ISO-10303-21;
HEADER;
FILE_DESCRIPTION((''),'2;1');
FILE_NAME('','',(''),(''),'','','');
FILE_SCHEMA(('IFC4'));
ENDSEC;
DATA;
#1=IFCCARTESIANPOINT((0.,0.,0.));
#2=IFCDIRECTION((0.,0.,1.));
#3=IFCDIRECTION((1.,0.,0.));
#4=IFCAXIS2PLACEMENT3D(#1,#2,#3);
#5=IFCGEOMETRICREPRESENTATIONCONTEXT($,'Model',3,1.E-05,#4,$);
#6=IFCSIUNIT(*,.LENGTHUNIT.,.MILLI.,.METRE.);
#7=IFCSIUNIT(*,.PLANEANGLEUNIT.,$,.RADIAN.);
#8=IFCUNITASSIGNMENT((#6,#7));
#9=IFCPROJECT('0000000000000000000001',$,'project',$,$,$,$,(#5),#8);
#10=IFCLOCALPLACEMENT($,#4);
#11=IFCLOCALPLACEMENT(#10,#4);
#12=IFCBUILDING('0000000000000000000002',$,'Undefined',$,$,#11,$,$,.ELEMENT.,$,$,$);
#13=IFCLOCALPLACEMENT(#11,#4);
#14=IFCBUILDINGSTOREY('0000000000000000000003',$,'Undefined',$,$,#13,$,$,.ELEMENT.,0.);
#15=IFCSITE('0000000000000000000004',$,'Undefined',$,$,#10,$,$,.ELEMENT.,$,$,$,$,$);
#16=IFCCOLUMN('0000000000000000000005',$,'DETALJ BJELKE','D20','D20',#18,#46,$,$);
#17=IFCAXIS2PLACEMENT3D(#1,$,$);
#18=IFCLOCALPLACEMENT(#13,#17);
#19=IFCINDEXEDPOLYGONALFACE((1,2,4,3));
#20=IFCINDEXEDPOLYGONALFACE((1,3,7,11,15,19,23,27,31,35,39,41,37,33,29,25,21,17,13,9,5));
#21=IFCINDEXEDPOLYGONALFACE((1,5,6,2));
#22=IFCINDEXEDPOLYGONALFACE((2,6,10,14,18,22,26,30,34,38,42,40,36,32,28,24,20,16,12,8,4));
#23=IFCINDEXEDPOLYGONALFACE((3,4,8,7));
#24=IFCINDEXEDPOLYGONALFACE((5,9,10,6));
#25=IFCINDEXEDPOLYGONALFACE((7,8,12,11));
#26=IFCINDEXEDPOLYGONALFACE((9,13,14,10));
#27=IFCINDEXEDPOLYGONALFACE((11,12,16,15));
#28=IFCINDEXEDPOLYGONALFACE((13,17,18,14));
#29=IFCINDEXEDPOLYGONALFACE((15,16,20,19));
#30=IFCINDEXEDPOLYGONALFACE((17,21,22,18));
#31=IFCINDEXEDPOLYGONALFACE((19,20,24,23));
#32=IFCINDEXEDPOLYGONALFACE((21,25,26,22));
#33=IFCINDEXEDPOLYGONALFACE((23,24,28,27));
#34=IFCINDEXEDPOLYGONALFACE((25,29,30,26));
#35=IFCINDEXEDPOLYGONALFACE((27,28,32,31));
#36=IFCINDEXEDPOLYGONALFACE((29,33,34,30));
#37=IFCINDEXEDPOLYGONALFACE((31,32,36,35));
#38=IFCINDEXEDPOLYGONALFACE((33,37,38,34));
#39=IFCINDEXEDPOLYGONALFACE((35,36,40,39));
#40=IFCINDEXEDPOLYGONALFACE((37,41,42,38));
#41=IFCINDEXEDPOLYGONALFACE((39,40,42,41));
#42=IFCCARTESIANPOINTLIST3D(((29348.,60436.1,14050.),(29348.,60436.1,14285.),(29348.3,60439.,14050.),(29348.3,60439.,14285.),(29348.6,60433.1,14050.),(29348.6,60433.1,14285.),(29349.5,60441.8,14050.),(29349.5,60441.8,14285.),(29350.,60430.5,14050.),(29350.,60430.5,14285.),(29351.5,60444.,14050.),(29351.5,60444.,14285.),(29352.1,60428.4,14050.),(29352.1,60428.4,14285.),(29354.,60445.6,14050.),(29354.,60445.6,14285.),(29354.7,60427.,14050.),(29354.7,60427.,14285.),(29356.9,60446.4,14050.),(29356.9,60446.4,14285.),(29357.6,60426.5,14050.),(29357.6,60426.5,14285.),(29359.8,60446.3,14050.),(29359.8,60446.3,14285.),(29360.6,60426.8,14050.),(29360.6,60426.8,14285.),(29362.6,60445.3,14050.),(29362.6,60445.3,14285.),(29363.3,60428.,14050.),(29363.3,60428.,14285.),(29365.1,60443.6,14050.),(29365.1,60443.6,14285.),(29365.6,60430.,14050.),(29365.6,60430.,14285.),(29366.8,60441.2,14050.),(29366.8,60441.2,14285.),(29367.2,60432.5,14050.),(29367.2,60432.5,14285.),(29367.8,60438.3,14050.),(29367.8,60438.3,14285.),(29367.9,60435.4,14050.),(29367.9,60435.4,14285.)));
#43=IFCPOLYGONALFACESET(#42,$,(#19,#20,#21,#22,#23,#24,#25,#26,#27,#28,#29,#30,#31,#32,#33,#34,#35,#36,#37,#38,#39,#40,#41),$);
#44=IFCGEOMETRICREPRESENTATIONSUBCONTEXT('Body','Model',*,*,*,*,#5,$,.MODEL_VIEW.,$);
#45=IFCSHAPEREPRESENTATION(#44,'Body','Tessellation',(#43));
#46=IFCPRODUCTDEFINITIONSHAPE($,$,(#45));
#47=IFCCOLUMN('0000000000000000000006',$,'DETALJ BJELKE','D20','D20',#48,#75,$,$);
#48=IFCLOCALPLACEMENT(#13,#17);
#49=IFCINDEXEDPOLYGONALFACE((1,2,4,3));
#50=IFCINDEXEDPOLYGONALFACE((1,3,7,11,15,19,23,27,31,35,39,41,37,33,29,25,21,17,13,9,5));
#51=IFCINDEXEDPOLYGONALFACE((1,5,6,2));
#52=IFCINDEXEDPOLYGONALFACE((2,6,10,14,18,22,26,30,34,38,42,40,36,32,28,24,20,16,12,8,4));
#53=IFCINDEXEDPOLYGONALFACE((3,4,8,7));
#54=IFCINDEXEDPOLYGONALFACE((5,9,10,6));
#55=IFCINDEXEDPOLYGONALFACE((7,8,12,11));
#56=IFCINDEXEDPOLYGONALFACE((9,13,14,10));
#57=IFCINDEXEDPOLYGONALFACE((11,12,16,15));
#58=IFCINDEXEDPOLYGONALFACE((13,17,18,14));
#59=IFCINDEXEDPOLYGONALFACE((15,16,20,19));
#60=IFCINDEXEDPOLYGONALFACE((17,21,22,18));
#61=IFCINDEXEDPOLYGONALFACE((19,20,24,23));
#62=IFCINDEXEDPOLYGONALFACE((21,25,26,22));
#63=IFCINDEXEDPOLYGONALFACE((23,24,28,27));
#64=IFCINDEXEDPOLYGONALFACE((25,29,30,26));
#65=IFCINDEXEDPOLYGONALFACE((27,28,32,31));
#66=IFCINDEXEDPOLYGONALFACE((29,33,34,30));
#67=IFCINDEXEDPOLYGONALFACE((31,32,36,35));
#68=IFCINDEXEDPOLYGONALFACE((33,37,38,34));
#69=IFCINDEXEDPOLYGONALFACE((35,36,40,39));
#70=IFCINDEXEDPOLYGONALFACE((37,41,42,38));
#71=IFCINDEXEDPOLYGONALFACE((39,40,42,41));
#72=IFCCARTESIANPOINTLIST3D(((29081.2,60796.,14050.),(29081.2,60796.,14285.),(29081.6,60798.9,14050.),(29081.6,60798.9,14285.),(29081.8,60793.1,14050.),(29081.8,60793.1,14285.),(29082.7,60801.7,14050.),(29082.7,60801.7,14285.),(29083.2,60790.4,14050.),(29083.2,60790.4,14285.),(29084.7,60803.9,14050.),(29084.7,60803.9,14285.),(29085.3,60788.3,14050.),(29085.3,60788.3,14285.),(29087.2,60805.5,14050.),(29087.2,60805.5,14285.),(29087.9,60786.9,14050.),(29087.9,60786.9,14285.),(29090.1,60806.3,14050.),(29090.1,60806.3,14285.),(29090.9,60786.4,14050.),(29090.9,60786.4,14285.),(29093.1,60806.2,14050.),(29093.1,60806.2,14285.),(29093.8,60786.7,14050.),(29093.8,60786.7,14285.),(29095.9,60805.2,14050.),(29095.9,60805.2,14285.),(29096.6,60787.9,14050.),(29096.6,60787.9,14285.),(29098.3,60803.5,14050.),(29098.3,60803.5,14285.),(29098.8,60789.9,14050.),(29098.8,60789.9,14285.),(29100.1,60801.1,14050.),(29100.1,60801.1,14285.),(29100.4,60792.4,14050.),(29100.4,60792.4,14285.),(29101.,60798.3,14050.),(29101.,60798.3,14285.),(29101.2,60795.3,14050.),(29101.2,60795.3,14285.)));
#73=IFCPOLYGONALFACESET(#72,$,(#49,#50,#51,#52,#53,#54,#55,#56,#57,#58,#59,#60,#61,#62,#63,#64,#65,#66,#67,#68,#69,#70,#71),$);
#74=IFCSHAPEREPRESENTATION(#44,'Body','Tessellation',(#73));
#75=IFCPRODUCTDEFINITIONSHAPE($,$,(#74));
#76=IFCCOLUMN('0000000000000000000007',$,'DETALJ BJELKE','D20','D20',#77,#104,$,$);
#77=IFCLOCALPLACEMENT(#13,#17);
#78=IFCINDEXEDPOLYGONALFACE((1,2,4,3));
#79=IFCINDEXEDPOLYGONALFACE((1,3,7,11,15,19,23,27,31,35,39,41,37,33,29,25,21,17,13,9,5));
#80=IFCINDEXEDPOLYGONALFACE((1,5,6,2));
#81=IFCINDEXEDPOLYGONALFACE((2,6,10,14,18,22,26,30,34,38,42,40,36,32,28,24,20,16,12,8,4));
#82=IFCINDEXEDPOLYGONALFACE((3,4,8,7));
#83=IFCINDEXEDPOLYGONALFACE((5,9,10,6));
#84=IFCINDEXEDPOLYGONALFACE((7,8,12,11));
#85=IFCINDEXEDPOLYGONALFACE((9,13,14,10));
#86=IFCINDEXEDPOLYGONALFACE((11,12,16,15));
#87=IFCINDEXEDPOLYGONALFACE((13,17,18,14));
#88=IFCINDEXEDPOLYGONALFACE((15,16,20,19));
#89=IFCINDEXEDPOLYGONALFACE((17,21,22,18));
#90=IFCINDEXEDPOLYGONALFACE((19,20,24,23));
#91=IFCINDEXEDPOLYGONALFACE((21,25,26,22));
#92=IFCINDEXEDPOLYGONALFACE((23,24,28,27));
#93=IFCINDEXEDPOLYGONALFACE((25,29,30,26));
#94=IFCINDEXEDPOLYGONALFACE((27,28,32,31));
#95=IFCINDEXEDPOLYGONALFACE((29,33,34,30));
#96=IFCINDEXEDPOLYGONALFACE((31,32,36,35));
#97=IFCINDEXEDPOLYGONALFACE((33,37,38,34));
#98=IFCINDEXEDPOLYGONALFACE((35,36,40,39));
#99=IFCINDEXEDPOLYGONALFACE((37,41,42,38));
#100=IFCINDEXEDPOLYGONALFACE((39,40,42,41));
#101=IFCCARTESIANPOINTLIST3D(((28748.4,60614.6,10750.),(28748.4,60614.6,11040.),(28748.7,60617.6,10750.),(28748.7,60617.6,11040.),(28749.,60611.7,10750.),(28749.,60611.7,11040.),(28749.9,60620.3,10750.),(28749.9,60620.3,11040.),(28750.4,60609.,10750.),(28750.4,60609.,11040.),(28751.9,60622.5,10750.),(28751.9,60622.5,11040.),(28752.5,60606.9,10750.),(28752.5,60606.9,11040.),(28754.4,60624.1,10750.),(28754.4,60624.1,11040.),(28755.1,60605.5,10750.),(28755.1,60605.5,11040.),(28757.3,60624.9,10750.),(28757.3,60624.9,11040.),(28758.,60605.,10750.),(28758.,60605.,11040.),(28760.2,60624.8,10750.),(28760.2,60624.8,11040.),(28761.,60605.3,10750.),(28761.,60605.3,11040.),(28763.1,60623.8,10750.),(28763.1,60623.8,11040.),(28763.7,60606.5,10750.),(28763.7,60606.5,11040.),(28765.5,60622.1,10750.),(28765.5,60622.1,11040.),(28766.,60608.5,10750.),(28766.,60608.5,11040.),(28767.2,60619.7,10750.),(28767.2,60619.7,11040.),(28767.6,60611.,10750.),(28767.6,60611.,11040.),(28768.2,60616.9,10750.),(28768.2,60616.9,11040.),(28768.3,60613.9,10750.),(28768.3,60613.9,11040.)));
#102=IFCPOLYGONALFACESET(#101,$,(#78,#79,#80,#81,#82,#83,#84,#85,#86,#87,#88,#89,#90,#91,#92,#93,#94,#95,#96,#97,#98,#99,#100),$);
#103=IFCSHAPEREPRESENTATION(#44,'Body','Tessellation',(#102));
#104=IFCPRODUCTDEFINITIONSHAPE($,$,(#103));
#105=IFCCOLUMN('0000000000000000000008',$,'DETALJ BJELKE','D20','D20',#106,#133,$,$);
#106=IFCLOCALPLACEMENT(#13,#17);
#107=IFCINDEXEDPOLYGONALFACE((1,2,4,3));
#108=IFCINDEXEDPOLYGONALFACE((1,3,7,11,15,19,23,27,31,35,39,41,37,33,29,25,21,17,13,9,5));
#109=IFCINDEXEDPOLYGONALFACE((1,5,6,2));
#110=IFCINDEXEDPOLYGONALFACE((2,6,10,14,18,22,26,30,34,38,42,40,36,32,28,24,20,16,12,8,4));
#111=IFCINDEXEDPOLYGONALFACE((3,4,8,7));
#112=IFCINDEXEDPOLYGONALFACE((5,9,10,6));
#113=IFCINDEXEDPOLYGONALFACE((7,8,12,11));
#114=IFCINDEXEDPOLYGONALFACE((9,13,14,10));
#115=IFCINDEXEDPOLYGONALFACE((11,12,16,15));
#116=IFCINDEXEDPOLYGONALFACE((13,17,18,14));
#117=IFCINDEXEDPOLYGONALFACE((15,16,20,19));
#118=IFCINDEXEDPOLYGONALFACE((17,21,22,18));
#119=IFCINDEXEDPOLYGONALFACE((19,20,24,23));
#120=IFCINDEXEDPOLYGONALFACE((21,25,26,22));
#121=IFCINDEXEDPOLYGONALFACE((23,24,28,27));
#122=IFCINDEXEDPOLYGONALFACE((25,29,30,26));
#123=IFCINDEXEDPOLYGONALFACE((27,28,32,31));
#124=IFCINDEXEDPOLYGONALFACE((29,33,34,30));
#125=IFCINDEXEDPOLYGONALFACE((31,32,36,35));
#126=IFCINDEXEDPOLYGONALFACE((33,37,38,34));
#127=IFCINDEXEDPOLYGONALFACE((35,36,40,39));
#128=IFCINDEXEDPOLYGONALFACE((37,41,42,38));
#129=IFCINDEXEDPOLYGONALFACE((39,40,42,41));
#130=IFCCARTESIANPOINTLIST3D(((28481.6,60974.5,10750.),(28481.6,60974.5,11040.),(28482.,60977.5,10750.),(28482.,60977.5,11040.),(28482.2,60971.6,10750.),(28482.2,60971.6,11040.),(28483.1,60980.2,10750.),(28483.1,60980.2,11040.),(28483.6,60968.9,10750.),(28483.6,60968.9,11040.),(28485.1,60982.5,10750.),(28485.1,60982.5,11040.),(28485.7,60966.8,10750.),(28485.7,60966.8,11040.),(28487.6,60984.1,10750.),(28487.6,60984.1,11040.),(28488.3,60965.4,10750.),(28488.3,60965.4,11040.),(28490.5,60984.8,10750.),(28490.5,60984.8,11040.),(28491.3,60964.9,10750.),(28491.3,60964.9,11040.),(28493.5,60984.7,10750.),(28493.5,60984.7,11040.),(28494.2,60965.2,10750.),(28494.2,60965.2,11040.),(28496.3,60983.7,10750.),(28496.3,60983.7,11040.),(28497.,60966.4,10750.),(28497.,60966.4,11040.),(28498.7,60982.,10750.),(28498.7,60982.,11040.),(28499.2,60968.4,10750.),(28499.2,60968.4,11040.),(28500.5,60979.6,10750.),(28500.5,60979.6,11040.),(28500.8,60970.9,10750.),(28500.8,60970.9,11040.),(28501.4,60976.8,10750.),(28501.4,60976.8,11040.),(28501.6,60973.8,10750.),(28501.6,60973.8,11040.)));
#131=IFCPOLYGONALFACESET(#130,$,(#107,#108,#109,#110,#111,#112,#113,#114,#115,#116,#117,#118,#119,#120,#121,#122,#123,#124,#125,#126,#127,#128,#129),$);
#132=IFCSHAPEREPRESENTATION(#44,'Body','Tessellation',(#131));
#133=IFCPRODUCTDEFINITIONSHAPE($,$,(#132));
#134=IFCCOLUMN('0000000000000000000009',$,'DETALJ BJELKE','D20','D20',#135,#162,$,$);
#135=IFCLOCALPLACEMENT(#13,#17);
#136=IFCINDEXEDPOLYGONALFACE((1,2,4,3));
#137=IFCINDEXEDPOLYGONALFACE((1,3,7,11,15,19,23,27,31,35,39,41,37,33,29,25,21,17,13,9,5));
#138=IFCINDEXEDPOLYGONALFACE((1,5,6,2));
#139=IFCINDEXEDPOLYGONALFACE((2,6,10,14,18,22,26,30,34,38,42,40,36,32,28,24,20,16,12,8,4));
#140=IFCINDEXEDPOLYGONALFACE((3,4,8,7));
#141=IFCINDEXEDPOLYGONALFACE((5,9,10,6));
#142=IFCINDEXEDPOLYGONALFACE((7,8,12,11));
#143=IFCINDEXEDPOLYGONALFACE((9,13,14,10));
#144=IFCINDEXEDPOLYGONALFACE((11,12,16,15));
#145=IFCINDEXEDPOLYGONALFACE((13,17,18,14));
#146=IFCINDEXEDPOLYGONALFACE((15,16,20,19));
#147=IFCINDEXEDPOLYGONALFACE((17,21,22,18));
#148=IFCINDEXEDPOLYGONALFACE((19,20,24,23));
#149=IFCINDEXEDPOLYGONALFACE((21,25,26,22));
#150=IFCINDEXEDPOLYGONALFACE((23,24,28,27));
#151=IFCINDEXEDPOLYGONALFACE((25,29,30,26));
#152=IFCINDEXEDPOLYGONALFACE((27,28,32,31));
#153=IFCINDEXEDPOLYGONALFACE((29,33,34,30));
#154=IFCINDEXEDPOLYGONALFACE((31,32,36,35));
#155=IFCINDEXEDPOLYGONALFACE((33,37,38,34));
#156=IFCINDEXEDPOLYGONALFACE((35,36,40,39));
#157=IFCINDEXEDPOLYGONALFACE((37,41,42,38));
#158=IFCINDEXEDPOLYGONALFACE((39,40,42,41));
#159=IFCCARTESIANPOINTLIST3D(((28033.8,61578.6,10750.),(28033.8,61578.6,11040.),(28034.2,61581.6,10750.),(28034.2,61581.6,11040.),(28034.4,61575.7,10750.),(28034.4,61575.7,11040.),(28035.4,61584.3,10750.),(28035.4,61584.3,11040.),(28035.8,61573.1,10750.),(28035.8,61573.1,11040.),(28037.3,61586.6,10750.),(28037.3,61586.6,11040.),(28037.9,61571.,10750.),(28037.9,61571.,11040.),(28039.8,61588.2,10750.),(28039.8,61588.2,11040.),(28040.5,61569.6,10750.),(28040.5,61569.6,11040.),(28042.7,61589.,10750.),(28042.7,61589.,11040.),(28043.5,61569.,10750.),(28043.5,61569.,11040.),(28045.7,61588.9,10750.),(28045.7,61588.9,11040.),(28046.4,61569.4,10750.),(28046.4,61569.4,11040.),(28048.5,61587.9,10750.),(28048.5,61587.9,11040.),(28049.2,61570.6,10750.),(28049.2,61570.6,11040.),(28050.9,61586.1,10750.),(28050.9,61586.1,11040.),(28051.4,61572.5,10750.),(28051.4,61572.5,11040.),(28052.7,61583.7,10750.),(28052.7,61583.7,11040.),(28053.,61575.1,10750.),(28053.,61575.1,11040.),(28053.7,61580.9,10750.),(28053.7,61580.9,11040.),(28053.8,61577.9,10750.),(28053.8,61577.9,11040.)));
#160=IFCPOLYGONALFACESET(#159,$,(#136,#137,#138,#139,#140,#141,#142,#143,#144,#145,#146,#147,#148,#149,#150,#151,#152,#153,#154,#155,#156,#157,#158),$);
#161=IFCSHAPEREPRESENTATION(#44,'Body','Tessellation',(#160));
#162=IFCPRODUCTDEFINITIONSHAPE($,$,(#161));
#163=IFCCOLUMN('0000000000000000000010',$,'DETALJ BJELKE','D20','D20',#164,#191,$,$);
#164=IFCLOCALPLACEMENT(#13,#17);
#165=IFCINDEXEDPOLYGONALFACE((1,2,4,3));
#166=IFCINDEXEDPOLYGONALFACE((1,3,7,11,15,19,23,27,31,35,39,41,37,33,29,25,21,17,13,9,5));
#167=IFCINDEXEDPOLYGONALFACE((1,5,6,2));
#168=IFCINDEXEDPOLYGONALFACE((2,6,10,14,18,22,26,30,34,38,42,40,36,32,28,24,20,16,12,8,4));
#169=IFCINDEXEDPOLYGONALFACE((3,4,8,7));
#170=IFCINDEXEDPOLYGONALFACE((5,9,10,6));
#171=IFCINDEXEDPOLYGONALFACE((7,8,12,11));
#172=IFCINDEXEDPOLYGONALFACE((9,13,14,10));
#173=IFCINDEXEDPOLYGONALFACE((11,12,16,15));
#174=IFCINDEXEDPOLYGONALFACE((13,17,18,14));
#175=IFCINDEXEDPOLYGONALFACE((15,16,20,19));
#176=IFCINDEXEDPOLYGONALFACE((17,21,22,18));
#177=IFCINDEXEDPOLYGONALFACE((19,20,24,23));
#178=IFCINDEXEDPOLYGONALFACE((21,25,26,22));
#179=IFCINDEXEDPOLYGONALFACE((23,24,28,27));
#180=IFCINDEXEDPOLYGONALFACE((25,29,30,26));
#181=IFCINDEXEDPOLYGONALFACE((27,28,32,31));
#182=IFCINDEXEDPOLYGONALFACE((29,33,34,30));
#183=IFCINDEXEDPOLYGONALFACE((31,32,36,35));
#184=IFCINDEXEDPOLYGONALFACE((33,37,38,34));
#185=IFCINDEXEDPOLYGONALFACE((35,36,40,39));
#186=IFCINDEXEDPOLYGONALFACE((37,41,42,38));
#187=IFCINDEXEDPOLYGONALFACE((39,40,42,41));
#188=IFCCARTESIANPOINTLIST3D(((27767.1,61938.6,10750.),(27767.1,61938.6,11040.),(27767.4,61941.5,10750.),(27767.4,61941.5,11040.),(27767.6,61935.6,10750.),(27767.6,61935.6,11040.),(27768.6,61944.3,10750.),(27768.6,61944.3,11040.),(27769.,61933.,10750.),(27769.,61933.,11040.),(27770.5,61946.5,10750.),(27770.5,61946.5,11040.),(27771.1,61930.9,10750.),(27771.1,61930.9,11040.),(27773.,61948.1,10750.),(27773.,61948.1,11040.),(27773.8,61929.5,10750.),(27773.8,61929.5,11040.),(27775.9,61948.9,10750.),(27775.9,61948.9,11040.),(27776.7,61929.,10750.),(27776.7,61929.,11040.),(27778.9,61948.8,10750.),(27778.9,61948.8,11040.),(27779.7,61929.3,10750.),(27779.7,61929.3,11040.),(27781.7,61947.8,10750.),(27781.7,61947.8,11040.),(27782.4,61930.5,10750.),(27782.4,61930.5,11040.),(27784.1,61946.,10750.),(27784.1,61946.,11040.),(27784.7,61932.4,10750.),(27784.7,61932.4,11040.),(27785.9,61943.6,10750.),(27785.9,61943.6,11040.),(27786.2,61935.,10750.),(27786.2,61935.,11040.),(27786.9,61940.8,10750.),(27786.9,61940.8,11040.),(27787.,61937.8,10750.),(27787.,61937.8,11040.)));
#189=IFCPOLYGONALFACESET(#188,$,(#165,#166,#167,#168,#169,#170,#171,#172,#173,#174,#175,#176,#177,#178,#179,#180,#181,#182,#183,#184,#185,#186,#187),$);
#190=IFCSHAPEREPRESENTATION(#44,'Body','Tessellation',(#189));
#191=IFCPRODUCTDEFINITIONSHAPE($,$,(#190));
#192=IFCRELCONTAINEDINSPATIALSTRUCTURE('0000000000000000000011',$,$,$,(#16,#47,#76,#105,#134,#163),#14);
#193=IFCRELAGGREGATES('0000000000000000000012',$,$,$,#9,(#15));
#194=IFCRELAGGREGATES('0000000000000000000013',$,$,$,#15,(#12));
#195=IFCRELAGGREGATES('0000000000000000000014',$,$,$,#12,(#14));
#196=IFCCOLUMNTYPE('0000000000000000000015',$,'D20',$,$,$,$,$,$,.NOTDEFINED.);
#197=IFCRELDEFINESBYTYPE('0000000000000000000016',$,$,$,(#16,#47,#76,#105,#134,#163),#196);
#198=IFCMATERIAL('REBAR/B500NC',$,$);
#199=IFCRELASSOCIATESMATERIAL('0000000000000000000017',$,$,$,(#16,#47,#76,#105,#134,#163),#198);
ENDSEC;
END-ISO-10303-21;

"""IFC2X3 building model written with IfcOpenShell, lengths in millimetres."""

from ifc_helpers import new_model, si_unit, frame, origin_with_axes, origin_2d_with_axis, place, context, subcontext, project, spatial, circle, extrude, material, type_object, element, save


model = new_model("IFC2X3")

# Units and contexts
model_context = context("Model", 3, precision=1e-05, world=origin_with_axes())
body_context = subcontext(model_context, "Body", "Model", "MODEL_VIEW")
ifc_project = project(units=[si_unit("LENGTHUNIT", "METRE", prefix="MILLI"), si_unit("PLANEANGLEUNIT", "RADIAN")], contexts=[model_context])

# Site, building, storey
site_placement = place(None, origin_with_axes())
site = spatial("IfcSite", under=ifc_project, at=site_placement, Name="Undefined", CompositionType="ELEMENT")
building_placement = place(site_placement, origin_with_axes())
building = spatial("IfcBuilding", under=site, at=building_placement, Name="Undefined", CompositionType="ELEMENT")
storey_placement = place(building_placement, origin_with_axes())
storey = spatial("IfcBuildingStorey", under=building, at=storey_placement, Name="Undefined", CompositionType="ELEMENT", Elevation=0.0)

# Columns
ifc_material_1 = material(Name="REBAR/B500NC")
column_type_1 = type_object("IfcColumnType", Name="D20", PredefinedType="NOTDEFINED")
for number, where, z_axis, x_axis, name in (
    (1, (29358.0, 60436.5, 14050.0), (0.0, 0.0, 1.0), (-0.595472, 0.803376, 0.0), "DETALJ BJELKE"),
    (2, (29091.2, 60796.4, 14050.0), (0.0, 0.0, 1.0), (-0.595472, 0.803376, 0.0), "DETALJ BJELKE"),
):
    element("IfcColumn", number, at=place(storey_placement, frame(where, z_axis=z_axis, x_axis=x_axis)), inside=storey, type_object=column_type_1, material=ifc_material_1, Name=name, Description="D20", ObjectType="D20", context=body_context, shape_type="SweptSolid", body=[
        extrude(circle(Radius=10.0, at=origin_2d_with_axis()), frame((0.0, 0.0, 235.0), z_axis=(0.0, 0.0, -1.0), x_axis=(0.0, 1.0, 0.0)), (0.0, 0.0, 1.0), 235.0),
    ])
for number, where, z_axis, x_axis, name in (
    (3, (28758.4, 60615.0, 10750.0), (0.0, 0.0, 1.0), (-0.595472, 0.803376, 0.0), "DETALJ BJELKE"),
    (4, (28491.6, 60974.9, 10750.0), (0.0, 0.0, 1.0), (-0.595472, 0.803376, 0.0), "DETALJ BJELKE"),
    (5, (28043.8, 61579.0, 10750.0), (0.0, 0.0, 1.0), (-0.595472, 0.803376, 0.0), "DETALJ BJELKE"),
    (6, (27777.1, 61938.9, 10750.0), (0.0, 0.0, 1.0), (-0.595472, 0.803376, 0.0), "DETALJ BJELKE"),
):
    element("IfcColumn", number, at=place(storey_placement, frame(where, z_axis=z_axis, x_axis=x_axis)), inside=storey, type_object=column_type_1, material=ifc_material_1, Name=name, Description="D20", ObjectType="D20", context=body_context, shape_type="SweptSolid", body=[
        extrude(circle(Radius=10.0, at=origin_2d_with_axis()), frame((0.0, 0.0, 290.0), z_axis=(0.0, 0.0, -1.0), x_axis=(0.0, 1.0, 0.0)), (0.0, 0.0, 1.0), 290.0),
    ])

save(model, "model.ifc")
